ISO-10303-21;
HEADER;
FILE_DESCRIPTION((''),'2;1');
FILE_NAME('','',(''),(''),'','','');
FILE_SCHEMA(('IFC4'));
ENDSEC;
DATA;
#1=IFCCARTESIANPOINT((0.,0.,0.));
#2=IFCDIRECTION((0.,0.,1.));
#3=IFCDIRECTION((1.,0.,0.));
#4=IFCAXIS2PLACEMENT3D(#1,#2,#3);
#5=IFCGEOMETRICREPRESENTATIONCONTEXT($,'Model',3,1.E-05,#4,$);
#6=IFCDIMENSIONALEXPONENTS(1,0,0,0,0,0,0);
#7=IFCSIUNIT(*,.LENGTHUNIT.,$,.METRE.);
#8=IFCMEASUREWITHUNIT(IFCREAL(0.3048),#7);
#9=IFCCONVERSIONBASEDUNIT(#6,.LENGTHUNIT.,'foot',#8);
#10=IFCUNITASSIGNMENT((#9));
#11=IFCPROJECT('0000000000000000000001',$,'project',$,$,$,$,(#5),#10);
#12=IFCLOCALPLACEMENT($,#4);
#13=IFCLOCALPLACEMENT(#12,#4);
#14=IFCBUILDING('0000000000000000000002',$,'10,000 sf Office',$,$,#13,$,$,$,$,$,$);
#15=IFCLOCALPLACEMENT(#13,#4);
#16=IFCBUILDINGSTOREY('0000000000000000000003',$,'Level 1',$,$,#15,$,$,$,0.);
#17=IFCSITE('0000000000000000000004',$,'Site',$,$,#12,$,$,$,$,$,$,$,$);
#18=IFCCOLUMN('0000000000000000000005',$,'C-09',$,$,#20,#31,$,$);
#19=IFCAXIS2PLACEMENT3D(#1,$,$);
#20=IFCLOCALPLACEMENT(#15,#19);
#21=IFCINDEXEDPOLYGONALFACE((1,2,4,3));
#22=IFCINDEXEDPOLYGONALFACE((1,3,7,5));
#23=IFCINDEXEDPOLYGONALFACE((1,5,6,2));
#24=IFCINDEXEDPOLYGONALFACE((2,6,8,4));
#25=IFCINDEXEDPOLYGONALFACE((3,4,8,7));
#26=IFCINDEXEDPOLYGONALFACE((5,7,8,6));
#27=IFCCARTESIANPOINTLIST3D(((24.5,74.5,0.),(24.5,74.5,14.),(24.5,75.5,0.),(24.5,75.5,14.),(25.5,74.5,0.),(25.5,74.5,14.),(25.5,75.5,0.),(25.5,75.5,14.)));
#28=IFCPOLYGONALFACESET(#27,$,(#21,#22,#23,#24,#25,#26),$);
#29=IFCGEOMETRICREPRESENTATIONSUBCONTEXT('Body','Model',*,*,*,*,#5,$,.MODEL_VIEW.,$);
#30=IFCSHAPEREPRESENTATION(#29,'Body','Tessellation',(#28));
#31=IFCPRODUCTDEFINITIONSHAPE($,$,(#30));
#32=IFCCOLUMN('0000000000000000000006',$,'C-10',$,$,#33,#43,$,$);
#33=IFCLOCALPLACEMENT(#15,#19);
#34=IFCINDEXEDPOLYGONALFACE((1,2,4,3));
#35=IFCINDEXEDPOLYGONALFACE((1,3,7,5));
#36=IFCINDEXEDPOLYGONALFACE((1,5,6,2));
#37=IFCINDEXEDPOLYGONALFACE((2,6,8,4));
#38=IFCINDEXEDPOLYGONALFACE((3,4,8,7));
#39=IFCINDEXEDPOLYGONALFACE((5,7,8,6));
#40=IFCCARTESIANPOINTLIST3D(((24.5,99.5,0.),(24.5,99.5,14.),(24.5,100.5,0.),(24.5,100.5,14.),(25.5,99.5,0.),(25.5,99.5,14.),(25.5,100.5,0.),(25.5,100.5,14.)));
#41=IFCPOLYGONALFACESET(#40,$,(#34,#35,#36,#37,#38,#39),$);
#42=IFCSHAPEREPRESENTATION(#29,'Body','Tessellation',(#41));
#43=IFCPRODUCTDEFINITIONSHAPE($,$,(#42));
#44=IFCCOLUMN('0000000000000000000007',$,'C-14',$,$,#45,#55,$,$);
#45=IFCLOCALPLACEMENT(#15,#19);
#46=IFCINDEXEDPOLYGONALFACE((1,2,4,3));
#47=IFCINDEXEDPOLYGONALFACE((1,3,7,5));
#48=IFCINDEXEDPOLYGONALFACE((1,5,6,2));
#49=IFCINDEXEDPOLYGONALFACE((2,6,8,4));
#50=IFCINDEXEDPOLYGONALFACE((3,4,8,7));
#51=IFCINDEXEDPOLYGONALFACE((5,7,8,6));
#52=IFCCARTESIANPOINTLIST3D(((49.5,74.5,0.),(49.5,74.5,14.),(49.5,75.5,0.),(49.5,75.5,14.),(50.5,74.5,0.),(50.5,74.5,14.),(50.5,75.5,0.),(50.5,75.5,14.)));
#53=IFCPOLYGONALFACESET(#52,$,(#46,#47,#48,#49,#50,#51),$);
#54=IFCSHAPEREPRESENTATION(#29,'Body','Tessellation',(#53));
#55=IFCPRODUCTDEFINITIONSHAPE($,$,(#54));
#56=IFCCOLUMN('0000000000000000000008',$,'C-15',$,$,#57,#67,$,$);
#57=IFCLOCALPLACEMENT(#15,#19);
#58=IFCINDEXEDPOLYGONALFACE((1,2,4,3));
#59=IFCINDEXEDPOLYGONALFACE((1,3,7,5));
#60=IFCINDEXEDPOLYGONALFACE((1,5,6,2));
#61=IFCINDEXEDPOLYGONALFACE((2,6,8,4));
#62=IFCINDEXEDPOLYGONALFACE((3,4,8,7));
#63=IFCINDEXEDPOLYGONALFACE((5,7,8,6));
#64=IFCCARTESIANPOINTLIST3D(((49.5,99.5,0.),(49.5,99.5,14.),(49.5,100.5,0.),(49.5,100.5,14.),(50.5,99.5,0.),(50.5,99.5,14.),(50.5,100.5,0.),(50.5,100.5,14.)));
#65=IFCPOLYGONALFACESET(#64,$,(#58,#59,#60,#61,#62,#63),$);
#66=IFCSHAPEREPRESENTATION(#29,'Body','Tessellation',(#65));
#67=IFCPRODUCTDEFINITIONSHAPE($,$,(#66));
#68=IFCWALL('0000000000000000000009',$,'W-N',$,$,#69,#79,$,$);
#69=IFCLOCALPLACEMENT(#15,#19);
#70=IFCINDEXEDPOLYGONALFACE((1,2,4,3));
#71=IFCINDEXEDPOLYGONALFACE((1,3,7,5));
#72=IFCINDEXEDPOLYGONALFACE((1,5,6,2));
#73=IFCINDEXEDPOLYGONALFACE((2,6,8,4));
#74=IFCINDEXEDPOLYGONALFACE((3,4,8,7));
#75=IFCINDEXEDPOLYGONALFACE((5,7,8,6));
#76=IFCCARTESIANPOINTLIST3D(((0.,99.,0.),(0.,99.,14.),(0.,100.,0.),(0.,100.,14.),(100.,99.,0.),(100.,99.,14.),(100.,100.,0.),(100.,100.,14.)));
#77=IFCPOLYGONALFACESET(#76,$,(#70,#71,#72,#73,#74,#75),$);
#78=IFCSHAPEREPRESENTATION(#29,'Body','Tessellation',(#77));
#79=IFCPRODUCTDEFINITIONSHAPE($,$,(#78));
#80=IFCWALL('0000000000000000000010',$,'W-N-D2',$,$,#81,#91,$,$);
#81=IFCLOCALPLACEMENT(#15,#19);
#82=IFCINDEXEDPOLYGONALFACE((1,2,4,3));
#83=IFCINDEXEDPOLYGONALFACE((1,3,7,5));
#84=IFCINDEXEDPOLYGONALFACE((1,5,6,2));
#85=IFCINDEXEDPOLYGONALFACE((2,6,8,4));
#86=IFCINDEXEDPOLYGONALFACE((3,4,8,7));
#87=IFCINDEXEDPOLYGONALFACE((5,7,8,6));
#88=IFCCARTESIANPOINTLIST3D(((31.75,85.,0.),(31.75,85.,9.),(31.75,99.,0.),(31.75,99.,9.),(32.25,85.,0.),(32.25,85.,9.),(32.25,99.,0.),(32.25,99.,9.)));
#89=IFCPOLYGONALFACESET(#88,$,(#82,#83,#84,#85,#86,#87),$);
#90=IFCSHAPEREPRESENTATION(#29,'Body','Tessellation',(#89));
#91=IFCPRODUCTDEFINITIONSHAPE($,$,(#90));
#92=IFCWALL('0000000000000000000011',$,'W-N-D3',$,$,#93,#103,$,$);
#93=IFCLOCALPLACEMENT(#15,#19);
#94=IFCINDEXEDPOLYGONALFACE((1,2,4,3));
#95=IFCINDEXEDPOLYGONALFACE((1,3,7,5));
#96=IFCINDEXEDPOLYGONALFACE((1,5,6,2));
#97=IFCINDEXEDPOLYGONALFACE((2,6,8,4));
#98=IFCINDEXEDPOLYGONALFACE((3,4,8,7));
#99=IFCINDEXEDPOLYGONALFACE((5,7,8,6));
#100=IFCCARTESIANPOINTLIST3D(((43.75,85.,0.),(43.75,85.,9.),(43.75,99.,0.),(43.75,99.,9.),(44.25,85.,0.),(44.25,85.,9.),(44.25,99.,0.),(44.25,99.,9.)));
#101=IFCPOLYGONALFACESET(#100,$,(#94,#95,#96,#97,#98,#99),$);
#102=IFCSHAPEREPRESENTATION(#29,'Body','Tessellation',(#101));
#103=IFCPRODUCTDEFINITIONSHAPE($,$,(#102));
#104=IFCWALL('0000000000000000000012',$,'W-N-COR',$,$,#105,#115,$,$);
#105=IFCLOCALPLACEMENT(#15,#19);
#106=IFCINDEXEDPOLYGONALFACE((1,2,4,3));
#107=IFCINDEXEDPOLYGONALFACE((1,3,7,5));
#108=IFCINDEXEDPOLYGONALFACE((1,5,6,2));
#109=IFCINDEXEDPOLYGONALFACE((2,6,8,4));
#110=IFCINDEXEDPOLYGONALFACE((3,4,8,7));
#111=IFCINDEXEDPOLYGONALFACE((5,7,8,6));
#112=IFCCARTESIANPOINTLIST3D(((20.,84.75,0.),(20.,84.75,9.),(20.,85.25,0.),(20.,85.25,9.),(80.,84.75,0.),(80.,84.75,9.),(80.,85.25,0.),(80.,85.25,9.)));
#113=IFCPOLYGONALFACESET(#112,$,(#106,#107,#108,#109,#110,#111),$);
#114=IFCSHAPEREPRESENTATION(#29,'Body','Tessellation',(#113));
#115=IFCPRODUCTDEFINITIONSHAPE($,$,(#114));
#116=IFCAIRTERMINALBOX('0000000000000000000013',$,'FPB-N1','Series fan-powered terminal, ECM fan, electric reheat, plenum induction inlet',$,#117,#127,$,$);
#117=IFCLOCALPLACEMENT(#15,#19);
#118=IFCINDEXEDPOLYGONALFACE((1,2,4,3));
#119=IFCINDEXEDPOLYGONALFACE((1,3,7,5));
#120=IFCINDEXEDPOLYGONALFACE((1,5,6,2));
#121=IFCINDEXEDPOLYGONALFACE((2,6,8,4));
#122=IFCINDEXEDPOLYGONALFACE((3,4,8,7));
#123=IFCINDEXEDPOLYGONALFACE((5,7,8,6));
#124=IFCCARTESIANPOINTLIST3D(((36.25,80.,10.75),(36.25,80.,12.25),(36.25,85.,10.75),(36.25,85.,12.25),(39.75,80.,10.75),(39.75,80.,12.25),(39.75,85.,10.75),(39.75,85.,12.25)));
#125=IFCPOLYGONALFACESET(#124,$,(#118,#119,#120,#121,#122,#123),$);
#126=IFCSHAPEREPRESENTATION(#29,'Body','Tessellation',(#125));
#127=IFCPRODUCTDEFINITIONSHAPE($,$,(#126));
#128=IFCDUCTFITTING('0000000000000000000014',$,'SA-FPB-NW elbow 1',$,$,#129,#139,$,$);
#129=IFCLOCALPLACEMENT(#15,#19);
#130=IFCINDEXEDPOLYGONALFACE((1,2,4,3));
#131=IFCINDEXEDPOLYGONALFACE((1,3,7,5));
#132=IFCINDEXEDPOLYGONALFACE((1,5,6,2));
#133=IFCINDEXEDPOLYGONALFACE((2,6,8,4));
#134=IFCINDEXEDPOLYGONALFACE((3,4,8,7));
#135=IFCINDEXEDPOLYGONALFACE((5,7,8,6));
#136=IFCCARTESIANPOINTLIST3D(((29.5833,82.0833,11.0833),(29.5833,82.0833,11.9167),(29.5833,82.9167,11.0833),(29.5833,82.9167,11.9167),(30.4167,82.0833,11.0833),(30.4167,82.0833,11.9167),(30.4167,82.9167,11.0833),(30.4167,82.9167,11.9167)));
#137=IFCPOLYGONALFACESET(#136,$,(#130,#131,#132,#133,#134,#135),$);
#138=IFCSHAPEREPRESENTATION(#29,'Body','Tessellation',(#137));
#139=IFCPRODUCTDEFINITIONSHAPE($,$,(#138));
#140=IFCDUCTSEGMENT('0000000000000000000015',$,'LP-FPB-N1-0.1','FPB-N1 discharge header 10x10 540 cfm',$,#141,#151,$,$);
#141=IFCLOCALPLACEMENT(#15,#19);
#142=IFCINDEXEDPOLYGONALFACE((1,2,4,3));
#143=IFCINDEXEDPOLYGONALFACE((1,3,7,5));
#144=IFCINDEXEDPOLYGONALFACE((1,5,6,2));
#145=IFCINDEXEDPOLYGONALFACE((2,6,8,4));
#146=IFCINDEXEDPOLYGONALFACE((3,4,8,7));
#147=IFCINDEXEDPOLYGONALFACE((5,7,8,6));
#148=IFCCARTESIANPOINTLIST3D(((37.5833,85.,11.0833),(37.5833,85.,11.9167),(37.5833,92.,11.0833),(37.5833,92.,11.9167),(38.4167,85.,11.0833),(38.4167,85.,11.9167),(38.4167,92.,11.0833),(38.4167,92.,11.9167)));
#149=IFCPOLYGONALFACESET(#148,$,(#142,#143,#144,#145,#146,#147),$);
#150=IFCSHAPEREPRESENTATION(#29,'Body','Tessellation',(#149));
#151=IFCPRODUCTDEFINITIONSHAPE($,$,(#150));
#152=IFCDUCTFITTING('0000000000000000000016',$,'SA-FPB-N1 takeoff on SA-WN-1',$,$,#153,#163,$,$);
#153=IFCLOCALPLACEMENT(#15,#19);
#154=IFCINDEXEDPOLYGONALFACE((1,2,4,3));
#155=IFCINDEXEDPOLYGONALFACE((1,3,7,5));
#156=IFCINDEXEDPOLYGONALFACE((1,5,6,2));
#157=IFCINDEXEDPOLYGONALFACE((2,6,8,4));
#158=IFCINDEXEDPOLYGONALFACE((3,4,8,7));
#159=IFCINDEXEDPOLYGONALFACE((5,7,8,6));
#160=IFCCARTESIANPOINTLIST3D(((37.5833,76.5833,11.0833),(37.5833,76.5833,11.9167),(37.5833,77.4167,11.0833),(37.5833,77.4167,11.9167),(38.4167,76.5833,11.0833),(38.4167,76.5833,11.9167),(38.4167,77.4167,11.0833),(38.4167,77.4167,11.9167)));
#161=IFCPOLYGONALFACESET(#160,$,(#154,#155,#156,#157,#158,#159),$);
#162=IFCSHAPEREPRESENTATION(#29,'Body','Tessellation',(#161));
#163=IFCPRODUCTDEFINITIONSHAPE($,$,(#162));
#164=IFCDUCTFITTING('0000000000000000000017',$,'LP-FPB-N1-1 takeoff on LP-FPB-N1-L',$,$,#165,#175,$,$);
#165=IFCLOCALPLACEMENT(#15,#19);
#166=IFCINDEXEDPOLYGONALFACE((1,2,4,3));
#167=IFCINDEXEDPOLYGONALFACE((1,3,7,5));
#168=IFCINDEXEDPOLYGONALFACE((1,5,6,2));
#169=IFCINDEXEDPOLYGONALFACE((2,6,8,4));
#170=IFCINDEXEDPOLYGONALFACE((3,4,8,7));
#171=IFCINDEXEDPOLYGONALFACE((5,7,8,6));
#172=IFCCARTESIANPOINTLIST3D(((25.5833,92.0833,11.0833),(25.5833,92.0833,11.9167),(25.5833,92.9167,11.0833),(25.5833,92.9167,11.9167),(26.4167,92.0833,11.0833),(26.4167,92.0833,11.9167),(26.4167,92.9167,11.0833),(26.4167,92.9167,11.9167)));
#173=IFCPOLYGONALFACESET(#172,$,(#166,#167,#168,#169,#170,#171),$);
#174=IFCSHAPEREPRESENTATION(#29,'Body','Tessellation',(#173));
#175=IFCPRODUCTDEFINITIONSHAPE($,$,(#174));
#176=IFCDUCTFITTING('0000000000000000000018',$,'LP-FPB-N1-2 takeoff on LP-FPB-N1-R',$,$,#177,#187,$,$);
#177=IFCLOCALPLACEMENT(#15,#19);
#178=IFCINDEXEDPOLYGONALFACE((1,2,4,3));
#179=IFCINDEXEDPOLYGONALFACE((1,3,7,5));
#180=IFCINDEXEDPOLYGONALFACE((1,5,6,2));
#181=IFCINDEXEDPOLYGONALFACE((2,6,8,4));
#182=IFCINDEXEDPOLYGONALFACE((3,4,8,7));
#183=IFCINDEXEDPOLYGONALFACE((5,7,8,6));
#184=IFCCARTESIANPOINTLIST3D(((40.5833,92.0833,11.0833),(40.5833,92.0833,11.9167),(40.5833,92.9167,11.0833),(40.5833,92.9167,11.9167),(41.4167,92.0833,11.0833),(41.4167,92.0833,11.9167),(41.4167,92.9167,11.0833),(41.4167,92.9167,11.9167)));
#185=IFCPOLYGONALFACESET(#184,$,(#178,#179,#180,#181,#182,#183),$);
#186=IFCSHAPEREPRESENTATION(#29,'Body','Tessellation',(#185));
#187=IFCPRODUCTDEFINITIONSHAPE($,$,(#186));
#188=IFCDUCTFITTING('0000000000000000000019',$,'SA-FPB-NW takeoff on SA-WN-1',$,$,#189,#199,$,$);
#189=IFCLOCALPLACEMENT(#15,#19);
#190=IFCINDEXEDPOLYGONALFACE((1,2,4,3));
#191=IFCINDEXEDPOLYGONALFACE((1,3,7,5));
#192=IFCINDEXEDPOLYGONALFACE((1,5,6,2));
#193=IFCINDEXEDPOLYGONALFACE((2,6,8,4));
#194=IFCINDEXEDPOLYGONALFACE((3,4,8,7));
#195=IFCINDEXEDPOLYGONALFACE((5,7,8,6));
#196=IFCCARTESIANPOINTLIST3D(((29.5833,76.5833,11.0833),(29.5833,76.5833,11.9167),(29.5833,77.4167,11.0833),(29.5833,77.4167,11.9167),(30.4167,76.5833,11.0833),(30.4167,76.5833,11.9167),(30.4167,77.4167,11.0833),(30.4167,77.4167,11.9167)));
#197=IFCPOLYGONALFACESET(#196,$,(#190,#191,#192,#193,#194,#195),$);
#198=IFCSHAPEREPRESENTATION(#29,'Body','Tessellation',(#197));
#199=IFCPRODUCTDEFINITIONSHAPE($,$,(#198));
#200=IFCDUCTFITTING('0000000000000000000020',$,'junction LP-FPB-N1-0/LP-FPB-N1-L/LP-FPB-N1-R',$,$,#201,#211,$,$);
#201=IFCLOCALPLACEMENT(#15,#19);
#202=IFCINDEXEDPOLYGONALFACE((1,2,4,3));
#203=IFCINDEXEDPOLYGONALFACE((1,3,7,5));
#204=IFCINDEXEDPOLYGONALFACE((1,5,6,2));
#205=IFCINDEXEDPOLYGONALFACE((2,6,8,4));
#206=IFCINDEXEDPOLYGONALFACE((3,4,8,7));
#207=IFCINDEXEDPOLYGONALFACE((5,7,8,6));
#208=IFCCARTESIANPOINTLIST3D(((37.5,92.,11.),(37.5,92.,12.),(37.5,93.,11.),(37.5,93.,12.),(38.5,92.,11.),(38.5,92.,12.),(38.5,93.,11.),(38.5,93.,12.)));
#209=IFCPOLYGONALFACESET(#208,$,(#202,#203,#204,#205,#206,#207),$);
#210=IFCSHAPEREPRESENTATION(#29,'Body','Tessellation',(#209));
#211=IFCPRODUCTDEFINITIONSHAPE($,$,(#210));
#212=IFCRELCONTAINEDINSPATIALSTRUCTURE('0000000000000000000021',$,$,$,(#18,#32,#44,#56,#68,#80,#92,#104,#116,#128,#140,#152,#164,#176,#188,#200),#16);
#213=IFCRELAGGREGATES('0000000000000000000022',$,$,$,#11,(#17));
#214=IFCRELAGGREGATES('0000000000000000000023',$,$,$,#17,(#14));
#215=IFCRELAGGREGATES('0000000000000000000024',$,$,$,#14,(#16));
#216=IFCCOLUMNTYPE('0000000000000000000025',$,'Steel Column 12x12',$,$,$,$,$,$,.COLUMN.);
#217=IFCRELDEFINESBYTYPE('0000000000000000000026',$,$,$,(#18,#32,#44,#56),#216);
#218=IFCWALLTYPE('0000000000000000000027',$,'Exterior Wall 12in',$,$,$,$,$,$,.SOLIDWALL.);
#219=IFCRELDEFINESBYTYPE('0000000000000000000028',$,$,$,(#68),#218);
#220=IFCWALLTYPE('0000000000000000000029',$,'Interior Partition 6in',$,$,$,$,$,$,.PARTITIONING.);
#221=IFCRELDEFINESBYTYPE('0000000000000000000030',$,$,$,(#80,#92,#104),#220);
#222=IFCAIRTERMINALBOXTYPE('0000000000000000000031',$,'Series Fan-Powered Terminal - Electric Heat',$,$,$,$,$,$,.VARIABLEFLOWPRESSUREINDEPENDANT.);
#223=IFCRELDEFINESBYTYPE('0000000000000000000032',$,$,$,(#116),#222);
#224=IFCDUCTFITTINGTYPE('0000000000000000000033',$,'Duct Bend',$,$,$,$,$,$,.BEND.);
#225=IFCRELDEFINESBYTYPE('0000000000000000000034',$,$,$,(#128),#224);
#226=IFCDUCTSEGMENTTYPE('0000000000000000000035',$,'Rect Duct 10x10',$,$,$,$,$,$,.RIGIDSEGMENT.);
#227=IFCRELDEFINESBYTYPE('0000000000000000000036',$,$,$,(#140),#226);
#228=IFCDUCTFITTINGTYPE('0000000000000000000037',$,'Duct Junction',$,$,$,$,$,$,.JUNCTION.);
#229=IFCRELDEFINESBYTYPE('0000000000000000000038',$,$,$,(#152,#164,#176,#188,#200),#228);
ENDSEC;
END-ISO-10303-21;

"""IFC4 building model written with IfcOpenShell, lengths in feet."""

from ifc_helpers import new_model, entity, si_unit, converted_unit, frame, origin_with_axes, place, context, subcontext, project, spatial, rectangle, extrude, type_object, element, save


model = new_model("IFC4")

# Units and contexts
model_context = context("Model", 3, precision=1e-05, world=origin_with_axes())
body_context = subcontext(model_context, "Body", "Model", "MODEL_VIEW")
ifc_project = project(units=[converted_unit("LENGTHUNIT", "foot", entity("IfcReal", 0.3048), si_unit("LENGTHUNIT", "METRE"), dimensions=[1, 0, 0, 0, 0, 0, 0])], contexts=[model_context])

# Site, building, storey
site_placement = place(None, origin_with_axes())
site = spatial("IfcSite", under=ifc_project, at=site_placement, Name="Site")
building_placement = place(site_placement, origin_with_axes())
building = spatial("IfcBuilding", under=site, at=building_placement, Name="10,000 sf Office")
storey_placement = place(building_placement, origin_with_axes())
storey = spatial("IfcBuildingStorey", under=building, at=storey_placement, Name="Level 1", Elevation=0.0)

# Columns
column_type = type_object("IfcColumnType", Name="Steel Column 12x12", PredefinedType="COLUMN")
for number, where, z_axis, x_axis, name in (
    (1, (25.0, 75.0, 0.0), (0.0, 0.0, 1.0), (1.0, 0.0, 0.0), "C-09"),
    (2, (25.0, 100.0, 0.0), (0.0, 0.0, 1.0), (1.0, 0.0, 0.0), "C-10"),
    (3, (50.0, 75.0, 0.0), (0.0, 0.0, 1.0), (1.0, 0.0, 0.0), "C-14"),
    (4, (50.0, 100.0, 0.0), (0.0, 0.0, 1.0), (1.0, 0.0, 0.0), "C-15"),
):
    element("IfcColumn", number, at=place(storey_placement, frame(where, z_axis=z_axis, x_axis=x_axis)), inside=storey, type_object=column_type, Name=name, context=body_context, shape_type="SweptSolid", body=[
        extrude(rectangle(XDim=1.0, YDim=1.0), None, (0.0, 0.0, 1.0), 14.0),
    ])

# Walls
wall_type_1 = type_object("IfcWallType", Name="Exterior Wall 12in", PredefinedType="SOLIDWALL")
wall_1_placement = place(storey_placement, frame((50.0, 99.5, 0.0), z_axis=(0.0, 0.0, 1.0), x_axis=(-1.0, 0.0, 0.0)))
element("IfcWall", 5, at=wall_1_placement, inside=storey, type_object=wall_type_1, Name="W-N", context=body_context, shape_type="SweptSolid", body=[
    extrude(rectangle(XDim=100.0, YDim=1.0), None, (0.0, 0.0, 1.0), 14.0),
])
wall_type_2 = type_object("IfcWallType", Name="Interior Partition 6in", PredefinedType="PARTITIONING")
for number, where, z_axis, x_axis, name in (
    (6, (32.0, 92.0, 0.0), (0.0, 0.0, 1.0), (0.0, -1.0, 0.0), "W-N-D2"),
    (7, (44.0, 92.0, 0.0), (0.0, 0.0, 1.0), (0.0, -1.0, 0.0), "W-N-D3"),
):
    element("IfcWall", number, at=place(storey_placement, frame(where, z_axis=z_axis, x_axis=x_axis)), inside=storey, type_object=wall_type_2, Name=name, context=body_context, shape_type="SweptSolid", body=[
        extrude(rectangle(XDim=14.0, YDim=0.5), None, (0.0, 0.0, 1.0), 9.0),
    ])
wall_2_placement = place(storey_placement, frame((50.0, 85.0, 0.0), z_axis=(0.0, 0.0, 1.0), x_axis=(1.0, 0.0, 0.0)))
element("IfcWall", 8, at=wall_2_placement, inside=storey, type_object=wall_type_2, Name="W-N-COR", context=body_context, shape_type="SweptSolid", body=[
    extrude(rectangle(XDim=60.0, YDim=0.5), None, (0.0, 0.0, 1.0), 9.0),
])

# Air terminal box
air_terminal_box_type = type_object("IfcAirTerminalBoxType", Name="Series Fan-Powered Terminal - Electric Heat", PredefinedType="VARIABLEFLOWPRESSUREINDEPENDANT")
air_terminal_box_placement = place(storey_placement, frame((38.0, 82.5, 10.75), z_axis=(0.0, 0.0, 1.0), x_axis=(0.0, 1.0, 0.0)))
element("IfcAirTerminalBox", 9, at=air_terminal_box_placement, inside=storey, type_object=air_terminal_box_type, Name="FPB-N1", Description="Series fan-powered terminal, ECM fan, electric reheat, plenum induction inlet", context=body_context, shape_type="SweptSolid", body=[
    extrude(rectangle(XDim=5.0, YDim=3.5), None, (0.0, 0.0, 1.0), 1.5),
])

# Duct fitting
duct_fitting_type_1 = type_object("IfcDuctFittingType", Name="Duct Bend", PredefinedType="BEND")
duct_fitting_1_placement = place(storey_placement, frame((30.0, 82.5, 11.0833), z_axis=(0.0, 0.0, 1.0), x_axis=(1.0, 0.0, 0.0)))
element("IfcDuctFitting", 10, at=duct_fitting_1_placement, inside=storey, type_object=duct_fitting_type_1, Name="SA-FPB-NW elbow 1", context=body_context, shape_type="SweptSolid", body=[
    extrude(rectangle(XDim=0.8333, YDim=0.8333), None, (0.0, 0.0, 1.0), 0.8333),
])

# Duct segment
duct_segment_type_1 = type_object("IfcDuctSegmentType", Name="Rect Duct 10x10", PredefinedType="RIGIDSEGMENT")
duct_segment_1_placement = place(storey_placement, frame((38.0, 85.0, 11.5), z_axis=(0.0, 1.0, 0.0), x_axis=(-1.0, 0.0, 0.0)))
element("IfcDuctSegment", 11, at=duct_segment_1_placement, inside=storey, type_object=duct_segment_type_1, Name="LP-FPB-N1-0.1", Description="FPB-N1 discharge header 10x10 540 cfm", context=body_context, shape_type="SweptSolid", body=[
    extrude(rectangle(XDim=0.8333, YDim=0.8333), None, (0.0, 0.0, 1.0), 7.0),
])

# Duct fittings
duct_fitting_type_2 = type_object("IfcDuctFittingType", Name="Duct Junction", PredefinedType="JUNCTION")
for number, where, z_axis, x_axis, name in (
    (12, (38.0, 77.0, 11.0833), (0.0, 0.0, 1.0), (1.0, 0.0, 0.0), "SA-FPB-N1 takeoff on SA-WN-1"),
    (13, (26.0, 92.5, 11.0833), (0.0, 0.0, 1.0), (1.0, 0.0, 0.0), "LP-FPB-N1-1 takeoff on LP-FPB-N1-L"),
    (14, (41.0, 92.5, 11.0833), (0.0, 0.0, 1.0), (1.0, 0.0, 0.0), "LP-FPB-N1-2 takeoff on LP-FPB-N1-R"),
    (15, (30.0, 77.0, 11.0833), (0.0, 0.0, 1.0), (1.0, 0.0, 0.0), "SA-FPB-NW takeoff on SA-WN-1"),
):
    element("IfcDuctFitting", number, at=place(storey_placement, frame(where, z_axis=z_axis, x_axis=x_axis)), inside=storey, type_object=duct_fitting_type_2, Name=name, context=body_context, shape_type="SweptSolid", body=[
        extrude(rectangle(XDim=0.8333, YDim=0.8333), None, (0.0, 0.0, 1.0), 0.8333),
    ])
duct_fitting_2_placement = place(storey_placement, frame((38.0, 92.5, 11.0), z_axis=(0.0, 0.0, 1.0), x_axis=(1.0, 0.0, 0.0)))
element("IfcDuctFitting", 16, at=duct_fitting_2_placement, inside=storey, type_object=duct_fitting_type_2, Name="junction LP-FPB-N1-0/LP-FPB-N1-L/LP-FPB-N1-R", context=body_context, shape_type="SweptSolid", body=[
    extrude(rectangle(XDim=1.0, YDim=1.0), None, (0.0, 0.0, 1.0), 1.0),
])

save(model, "model.ifc")
